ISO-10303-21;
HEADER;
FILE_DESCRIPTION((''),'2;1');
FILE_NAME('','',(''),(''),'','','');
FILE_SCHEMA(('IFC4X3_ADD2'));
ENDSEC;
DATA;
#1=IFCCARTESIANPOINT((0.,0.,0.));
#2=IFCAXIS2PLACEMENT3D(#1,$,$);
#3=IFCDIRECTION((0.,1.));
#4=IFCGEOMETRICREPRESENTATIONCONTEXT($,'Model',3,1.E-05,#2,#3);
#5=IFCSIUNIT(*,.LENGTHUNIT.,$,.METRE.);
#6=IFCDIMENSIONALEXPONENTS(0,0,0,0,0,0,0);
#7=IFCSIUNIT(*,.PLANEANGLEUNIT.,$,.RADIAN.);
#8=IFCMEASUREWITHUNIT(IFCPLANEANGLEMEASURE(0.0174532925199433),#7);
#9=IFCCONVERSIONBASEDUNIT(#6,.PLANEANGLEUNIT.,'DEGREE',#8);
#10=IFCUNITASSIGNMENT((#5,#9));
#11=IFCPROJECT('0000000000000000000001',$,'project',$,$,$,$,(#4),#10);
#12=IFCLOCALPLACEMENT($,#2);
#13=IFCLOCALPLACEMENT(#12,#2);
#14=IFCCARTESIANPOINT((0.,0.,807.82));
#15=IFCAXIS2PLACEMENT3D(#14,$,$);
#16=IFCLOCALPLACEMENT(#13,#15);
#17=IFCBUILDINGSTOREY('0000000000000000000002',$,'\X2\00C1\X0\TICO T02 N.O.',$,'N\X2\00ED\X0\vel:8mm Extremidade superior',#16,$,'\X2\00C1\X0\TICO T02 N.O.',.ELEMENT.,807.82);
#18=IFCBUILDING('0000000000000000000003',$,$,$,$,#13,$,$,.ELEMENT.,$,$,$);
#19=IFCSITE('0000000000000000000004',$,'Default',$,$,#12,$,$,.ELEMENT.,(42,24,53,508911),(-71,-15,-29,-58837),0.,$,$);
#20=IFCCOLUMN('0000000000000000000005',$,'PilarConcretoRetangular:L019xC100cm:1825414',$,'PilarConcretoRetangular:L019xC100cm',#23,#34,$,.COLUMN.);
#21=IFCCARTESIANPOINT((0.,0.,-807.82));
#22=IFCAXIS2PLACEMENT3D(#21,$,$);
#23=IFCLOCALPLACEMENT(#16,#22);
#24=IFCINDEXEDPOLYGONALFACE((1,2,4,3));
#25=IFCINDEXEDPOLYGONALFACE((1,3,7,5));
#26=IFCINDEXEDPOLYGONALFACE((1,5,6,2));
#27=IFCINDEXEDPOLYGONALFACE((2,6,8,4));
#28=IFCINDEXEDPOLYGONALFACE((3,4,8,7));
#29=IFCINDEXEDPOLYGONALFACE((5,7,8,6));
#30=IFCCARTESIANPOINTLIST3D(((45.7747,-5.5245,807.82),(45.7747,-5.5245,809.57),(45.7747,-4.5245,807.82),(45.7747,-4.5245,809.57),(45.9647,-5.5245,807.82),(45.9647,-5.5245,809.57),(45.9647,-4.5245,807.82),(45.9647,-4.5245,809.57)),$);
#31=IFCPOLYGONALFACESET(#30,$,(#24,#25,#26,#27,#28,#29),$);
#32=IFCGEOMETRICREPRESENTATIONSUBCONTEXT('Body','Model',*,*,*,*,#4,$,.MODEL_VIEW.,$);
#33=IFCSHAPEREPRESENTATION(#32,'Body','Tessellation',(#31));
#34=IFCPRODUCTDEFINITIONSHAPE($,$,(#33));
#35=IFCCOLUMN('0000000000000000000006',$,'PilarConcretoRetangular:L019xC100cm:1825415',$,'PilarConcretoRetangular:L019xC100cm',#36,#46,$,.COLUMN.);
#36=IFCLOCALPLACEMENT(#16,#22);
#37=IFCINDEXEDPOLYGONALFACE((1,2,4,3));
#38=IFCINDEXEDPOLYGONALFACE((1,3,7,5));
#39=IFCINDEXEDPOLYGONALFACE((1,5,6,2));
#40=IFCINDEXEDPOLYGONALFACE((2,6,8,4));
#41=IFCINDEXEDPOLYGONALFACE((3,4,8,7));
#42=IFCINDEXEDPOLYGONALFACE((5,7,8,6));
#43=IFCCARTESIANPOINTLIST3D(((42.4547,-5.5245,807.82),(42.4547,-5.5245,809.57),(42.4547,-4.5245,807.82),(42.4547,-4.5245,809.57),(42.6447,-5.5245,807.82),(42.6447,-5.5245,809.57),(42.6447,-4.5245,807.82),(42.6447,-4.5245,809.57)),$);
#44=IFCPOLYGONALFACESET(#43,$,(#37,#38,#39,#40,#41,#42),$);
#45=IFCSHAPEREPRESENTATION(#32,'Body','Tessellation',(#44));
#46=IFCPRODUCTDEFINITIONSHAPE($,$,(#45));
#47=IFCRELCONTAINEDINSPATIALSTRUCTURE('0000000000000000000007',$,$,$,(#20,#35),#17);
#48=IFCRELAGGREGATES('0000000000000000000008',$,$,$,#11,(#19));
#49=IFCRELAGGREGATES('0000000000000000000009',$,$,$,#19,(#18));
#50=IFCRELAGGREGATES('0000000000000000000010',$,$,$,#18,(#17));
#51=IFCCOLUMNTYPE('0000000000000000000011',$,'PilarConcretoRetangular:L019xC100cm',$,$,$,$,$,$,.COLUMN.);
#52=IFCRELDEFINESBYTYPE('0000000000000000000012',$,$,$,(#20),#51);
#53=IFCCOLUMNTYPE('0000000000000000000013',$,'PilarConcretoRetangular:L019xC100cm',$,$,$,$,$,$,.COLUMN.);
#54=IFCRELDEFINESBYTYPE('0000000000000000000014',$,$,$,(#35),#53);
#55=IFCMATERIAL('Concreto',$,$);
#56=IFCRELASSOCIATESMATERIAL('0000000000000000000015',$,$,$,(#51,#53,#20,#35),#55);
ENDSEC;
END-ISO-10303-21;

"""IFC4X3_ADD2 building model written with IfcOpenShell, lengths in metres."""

from ifc_helpers import new_model, entity, si_unit, converted_unit, direction, frame, frame_2d, origin, place, context, subcontext, project, spatial, rectangle, extrude, source, transform, mapped, material, material_profile, profile_set, profile_usage, type_object, type_shapes, element, save


model = new_model("IFC4X3_ADD2")

# Units and contexts
model_context = context("Model", 3, precision=1e-05, world=origin(), true_north=direction((0.0, 1.0)))
body_context = subcontext(model_context, "Body", "Model", "MODEL_VIEW")
ifc_project = project(units=[si_unit("LENGTHUNIT", "METRE"), converted_unit("PLANEANGLEUNIT", "DEGREE", entity("IfcPlaneAngleMeasure", 0.0174532925199433), si_unit("PLANEANGLEUNIT", "RADIAN"), dimensions=[0, 0, 0, 0, 0, 0, 0])], contexts=[model_context])

# Site, building, storey
site_placement = place(None, origin())
site = spatial("IfcSite", under=ifc_project, at=site_placement, Name="Default", CompositionType="ELEMENT", RefLatitude=(42, 24, 53, 508911), RefLongitude=(-71, -15, -29, -58837), RefElevation=0.0)
building_placement = place(site_placement, origin())
building = spatial("IfcBuilding", under=site, at=building_placement, CompositionType="ELEMENT")
storey_placement = place(building_placement, frame((0.0, 0.0, 807.82)))
storey = spatial("IfcBuildingStorey", under=building, at=storey_placement, Name="ÁTICO T02 N.O.", ObjectType="Nível:8mm Extremidade superior", LongName="ÁTICO T02 N.O.", CompositionType="ELEMENT", Elevation=807.82)

# Columns
ifc_material = material(Name="Concreto")
ifc_material_profile_1 = material_profile(ifc_material, rectangle(XDim=0.19, YDim=1.0, at=frame_2d((0.0, 0.0), x_axis=(1.0, 0.0))), Name="L019xC100cm")
ifc_profile_set_1 = profile_set([ifc_material_profile_1], Name="L019xC100cm")
ifc_profile_usage_1 = profile_usage(ifc_profile_set_1)
column_type_1 = type_object("IfcColumnType", Name="PilarConcretoRetangular:L019xC100cm", PredefinedType="COLUMN", material=ifc_profile_set_1)
shared_shape_1 = source(origin(), body_context, "Body", "SweptSolid", [
    extrude(rectangle(XDim=0.19, YDim=1.0, at=frame_2d((0.0, 0.0), x_axis=(1.0, 0.0))), frame((45.8697, -5.0245, 807.82)), (0.0, 0.0, 1.0), 1.75),
])
type_shapes(column_type_1, [shared_shape_1])
column_1_placement = place(storey_placement, frame((0.0, 0.0, -807.82)))
element("IfcColumn", 1, at=column_1_placement, inside=storey, type_object=column_type_1, material=ifc_profile_usage_1, Name="PilarConcretoRetangular:L019xC100cm:1825414", ObjectType="PilarConcretoRetangular:L019xC100cm", PredefinedType="COLUMN", context=body_context, shape_type="MappedRepresentation", body=[
    mapped(shared_shape_1, transform((0.0, 0.0, 0.0), scale=1.0)),
])
column_type_2 = type_object("IfcColumnType", Name="PilarConcretoRetangular:L019xC100cm", PredefinedType="COLUMN", material=ifc_profile_set_1)
shared_shape_2 = source(origin(), body_context, "Body", "SweptSolid", [
    extrude(rectangle(XDim=0.19, YDim=1.0, at=frame_2d((0.0, 0.0), x_axis=(1.0, 0.0))), frame((42.5497, -5.0245, 807.82)), (0.0, 0.0, 1.0), 1.75),
])
type_shapes(column_type_2, [shared_shape_2])
column_2_placement = place(storey_placement, frame((0.0, 0.0, -807.82)))
element("IfcColumn", 2, at=column_2_placement, inside=storey, type_object=column_type_2, material=ifc_profile_usage_1, Name="PilarConcretoRetangular:L019xC100cm:1825415", ObjectType="PilarConcretoRetangular:L019xC100cm", PredefinedType="COLUMN", context=body_context, shape_type="MappedRepresentation", body=[
    mapped(shared_shape_2, transform((0.0, 0.0, 0.0), scale=1.0)),
])

save(model, "model.ifc")
